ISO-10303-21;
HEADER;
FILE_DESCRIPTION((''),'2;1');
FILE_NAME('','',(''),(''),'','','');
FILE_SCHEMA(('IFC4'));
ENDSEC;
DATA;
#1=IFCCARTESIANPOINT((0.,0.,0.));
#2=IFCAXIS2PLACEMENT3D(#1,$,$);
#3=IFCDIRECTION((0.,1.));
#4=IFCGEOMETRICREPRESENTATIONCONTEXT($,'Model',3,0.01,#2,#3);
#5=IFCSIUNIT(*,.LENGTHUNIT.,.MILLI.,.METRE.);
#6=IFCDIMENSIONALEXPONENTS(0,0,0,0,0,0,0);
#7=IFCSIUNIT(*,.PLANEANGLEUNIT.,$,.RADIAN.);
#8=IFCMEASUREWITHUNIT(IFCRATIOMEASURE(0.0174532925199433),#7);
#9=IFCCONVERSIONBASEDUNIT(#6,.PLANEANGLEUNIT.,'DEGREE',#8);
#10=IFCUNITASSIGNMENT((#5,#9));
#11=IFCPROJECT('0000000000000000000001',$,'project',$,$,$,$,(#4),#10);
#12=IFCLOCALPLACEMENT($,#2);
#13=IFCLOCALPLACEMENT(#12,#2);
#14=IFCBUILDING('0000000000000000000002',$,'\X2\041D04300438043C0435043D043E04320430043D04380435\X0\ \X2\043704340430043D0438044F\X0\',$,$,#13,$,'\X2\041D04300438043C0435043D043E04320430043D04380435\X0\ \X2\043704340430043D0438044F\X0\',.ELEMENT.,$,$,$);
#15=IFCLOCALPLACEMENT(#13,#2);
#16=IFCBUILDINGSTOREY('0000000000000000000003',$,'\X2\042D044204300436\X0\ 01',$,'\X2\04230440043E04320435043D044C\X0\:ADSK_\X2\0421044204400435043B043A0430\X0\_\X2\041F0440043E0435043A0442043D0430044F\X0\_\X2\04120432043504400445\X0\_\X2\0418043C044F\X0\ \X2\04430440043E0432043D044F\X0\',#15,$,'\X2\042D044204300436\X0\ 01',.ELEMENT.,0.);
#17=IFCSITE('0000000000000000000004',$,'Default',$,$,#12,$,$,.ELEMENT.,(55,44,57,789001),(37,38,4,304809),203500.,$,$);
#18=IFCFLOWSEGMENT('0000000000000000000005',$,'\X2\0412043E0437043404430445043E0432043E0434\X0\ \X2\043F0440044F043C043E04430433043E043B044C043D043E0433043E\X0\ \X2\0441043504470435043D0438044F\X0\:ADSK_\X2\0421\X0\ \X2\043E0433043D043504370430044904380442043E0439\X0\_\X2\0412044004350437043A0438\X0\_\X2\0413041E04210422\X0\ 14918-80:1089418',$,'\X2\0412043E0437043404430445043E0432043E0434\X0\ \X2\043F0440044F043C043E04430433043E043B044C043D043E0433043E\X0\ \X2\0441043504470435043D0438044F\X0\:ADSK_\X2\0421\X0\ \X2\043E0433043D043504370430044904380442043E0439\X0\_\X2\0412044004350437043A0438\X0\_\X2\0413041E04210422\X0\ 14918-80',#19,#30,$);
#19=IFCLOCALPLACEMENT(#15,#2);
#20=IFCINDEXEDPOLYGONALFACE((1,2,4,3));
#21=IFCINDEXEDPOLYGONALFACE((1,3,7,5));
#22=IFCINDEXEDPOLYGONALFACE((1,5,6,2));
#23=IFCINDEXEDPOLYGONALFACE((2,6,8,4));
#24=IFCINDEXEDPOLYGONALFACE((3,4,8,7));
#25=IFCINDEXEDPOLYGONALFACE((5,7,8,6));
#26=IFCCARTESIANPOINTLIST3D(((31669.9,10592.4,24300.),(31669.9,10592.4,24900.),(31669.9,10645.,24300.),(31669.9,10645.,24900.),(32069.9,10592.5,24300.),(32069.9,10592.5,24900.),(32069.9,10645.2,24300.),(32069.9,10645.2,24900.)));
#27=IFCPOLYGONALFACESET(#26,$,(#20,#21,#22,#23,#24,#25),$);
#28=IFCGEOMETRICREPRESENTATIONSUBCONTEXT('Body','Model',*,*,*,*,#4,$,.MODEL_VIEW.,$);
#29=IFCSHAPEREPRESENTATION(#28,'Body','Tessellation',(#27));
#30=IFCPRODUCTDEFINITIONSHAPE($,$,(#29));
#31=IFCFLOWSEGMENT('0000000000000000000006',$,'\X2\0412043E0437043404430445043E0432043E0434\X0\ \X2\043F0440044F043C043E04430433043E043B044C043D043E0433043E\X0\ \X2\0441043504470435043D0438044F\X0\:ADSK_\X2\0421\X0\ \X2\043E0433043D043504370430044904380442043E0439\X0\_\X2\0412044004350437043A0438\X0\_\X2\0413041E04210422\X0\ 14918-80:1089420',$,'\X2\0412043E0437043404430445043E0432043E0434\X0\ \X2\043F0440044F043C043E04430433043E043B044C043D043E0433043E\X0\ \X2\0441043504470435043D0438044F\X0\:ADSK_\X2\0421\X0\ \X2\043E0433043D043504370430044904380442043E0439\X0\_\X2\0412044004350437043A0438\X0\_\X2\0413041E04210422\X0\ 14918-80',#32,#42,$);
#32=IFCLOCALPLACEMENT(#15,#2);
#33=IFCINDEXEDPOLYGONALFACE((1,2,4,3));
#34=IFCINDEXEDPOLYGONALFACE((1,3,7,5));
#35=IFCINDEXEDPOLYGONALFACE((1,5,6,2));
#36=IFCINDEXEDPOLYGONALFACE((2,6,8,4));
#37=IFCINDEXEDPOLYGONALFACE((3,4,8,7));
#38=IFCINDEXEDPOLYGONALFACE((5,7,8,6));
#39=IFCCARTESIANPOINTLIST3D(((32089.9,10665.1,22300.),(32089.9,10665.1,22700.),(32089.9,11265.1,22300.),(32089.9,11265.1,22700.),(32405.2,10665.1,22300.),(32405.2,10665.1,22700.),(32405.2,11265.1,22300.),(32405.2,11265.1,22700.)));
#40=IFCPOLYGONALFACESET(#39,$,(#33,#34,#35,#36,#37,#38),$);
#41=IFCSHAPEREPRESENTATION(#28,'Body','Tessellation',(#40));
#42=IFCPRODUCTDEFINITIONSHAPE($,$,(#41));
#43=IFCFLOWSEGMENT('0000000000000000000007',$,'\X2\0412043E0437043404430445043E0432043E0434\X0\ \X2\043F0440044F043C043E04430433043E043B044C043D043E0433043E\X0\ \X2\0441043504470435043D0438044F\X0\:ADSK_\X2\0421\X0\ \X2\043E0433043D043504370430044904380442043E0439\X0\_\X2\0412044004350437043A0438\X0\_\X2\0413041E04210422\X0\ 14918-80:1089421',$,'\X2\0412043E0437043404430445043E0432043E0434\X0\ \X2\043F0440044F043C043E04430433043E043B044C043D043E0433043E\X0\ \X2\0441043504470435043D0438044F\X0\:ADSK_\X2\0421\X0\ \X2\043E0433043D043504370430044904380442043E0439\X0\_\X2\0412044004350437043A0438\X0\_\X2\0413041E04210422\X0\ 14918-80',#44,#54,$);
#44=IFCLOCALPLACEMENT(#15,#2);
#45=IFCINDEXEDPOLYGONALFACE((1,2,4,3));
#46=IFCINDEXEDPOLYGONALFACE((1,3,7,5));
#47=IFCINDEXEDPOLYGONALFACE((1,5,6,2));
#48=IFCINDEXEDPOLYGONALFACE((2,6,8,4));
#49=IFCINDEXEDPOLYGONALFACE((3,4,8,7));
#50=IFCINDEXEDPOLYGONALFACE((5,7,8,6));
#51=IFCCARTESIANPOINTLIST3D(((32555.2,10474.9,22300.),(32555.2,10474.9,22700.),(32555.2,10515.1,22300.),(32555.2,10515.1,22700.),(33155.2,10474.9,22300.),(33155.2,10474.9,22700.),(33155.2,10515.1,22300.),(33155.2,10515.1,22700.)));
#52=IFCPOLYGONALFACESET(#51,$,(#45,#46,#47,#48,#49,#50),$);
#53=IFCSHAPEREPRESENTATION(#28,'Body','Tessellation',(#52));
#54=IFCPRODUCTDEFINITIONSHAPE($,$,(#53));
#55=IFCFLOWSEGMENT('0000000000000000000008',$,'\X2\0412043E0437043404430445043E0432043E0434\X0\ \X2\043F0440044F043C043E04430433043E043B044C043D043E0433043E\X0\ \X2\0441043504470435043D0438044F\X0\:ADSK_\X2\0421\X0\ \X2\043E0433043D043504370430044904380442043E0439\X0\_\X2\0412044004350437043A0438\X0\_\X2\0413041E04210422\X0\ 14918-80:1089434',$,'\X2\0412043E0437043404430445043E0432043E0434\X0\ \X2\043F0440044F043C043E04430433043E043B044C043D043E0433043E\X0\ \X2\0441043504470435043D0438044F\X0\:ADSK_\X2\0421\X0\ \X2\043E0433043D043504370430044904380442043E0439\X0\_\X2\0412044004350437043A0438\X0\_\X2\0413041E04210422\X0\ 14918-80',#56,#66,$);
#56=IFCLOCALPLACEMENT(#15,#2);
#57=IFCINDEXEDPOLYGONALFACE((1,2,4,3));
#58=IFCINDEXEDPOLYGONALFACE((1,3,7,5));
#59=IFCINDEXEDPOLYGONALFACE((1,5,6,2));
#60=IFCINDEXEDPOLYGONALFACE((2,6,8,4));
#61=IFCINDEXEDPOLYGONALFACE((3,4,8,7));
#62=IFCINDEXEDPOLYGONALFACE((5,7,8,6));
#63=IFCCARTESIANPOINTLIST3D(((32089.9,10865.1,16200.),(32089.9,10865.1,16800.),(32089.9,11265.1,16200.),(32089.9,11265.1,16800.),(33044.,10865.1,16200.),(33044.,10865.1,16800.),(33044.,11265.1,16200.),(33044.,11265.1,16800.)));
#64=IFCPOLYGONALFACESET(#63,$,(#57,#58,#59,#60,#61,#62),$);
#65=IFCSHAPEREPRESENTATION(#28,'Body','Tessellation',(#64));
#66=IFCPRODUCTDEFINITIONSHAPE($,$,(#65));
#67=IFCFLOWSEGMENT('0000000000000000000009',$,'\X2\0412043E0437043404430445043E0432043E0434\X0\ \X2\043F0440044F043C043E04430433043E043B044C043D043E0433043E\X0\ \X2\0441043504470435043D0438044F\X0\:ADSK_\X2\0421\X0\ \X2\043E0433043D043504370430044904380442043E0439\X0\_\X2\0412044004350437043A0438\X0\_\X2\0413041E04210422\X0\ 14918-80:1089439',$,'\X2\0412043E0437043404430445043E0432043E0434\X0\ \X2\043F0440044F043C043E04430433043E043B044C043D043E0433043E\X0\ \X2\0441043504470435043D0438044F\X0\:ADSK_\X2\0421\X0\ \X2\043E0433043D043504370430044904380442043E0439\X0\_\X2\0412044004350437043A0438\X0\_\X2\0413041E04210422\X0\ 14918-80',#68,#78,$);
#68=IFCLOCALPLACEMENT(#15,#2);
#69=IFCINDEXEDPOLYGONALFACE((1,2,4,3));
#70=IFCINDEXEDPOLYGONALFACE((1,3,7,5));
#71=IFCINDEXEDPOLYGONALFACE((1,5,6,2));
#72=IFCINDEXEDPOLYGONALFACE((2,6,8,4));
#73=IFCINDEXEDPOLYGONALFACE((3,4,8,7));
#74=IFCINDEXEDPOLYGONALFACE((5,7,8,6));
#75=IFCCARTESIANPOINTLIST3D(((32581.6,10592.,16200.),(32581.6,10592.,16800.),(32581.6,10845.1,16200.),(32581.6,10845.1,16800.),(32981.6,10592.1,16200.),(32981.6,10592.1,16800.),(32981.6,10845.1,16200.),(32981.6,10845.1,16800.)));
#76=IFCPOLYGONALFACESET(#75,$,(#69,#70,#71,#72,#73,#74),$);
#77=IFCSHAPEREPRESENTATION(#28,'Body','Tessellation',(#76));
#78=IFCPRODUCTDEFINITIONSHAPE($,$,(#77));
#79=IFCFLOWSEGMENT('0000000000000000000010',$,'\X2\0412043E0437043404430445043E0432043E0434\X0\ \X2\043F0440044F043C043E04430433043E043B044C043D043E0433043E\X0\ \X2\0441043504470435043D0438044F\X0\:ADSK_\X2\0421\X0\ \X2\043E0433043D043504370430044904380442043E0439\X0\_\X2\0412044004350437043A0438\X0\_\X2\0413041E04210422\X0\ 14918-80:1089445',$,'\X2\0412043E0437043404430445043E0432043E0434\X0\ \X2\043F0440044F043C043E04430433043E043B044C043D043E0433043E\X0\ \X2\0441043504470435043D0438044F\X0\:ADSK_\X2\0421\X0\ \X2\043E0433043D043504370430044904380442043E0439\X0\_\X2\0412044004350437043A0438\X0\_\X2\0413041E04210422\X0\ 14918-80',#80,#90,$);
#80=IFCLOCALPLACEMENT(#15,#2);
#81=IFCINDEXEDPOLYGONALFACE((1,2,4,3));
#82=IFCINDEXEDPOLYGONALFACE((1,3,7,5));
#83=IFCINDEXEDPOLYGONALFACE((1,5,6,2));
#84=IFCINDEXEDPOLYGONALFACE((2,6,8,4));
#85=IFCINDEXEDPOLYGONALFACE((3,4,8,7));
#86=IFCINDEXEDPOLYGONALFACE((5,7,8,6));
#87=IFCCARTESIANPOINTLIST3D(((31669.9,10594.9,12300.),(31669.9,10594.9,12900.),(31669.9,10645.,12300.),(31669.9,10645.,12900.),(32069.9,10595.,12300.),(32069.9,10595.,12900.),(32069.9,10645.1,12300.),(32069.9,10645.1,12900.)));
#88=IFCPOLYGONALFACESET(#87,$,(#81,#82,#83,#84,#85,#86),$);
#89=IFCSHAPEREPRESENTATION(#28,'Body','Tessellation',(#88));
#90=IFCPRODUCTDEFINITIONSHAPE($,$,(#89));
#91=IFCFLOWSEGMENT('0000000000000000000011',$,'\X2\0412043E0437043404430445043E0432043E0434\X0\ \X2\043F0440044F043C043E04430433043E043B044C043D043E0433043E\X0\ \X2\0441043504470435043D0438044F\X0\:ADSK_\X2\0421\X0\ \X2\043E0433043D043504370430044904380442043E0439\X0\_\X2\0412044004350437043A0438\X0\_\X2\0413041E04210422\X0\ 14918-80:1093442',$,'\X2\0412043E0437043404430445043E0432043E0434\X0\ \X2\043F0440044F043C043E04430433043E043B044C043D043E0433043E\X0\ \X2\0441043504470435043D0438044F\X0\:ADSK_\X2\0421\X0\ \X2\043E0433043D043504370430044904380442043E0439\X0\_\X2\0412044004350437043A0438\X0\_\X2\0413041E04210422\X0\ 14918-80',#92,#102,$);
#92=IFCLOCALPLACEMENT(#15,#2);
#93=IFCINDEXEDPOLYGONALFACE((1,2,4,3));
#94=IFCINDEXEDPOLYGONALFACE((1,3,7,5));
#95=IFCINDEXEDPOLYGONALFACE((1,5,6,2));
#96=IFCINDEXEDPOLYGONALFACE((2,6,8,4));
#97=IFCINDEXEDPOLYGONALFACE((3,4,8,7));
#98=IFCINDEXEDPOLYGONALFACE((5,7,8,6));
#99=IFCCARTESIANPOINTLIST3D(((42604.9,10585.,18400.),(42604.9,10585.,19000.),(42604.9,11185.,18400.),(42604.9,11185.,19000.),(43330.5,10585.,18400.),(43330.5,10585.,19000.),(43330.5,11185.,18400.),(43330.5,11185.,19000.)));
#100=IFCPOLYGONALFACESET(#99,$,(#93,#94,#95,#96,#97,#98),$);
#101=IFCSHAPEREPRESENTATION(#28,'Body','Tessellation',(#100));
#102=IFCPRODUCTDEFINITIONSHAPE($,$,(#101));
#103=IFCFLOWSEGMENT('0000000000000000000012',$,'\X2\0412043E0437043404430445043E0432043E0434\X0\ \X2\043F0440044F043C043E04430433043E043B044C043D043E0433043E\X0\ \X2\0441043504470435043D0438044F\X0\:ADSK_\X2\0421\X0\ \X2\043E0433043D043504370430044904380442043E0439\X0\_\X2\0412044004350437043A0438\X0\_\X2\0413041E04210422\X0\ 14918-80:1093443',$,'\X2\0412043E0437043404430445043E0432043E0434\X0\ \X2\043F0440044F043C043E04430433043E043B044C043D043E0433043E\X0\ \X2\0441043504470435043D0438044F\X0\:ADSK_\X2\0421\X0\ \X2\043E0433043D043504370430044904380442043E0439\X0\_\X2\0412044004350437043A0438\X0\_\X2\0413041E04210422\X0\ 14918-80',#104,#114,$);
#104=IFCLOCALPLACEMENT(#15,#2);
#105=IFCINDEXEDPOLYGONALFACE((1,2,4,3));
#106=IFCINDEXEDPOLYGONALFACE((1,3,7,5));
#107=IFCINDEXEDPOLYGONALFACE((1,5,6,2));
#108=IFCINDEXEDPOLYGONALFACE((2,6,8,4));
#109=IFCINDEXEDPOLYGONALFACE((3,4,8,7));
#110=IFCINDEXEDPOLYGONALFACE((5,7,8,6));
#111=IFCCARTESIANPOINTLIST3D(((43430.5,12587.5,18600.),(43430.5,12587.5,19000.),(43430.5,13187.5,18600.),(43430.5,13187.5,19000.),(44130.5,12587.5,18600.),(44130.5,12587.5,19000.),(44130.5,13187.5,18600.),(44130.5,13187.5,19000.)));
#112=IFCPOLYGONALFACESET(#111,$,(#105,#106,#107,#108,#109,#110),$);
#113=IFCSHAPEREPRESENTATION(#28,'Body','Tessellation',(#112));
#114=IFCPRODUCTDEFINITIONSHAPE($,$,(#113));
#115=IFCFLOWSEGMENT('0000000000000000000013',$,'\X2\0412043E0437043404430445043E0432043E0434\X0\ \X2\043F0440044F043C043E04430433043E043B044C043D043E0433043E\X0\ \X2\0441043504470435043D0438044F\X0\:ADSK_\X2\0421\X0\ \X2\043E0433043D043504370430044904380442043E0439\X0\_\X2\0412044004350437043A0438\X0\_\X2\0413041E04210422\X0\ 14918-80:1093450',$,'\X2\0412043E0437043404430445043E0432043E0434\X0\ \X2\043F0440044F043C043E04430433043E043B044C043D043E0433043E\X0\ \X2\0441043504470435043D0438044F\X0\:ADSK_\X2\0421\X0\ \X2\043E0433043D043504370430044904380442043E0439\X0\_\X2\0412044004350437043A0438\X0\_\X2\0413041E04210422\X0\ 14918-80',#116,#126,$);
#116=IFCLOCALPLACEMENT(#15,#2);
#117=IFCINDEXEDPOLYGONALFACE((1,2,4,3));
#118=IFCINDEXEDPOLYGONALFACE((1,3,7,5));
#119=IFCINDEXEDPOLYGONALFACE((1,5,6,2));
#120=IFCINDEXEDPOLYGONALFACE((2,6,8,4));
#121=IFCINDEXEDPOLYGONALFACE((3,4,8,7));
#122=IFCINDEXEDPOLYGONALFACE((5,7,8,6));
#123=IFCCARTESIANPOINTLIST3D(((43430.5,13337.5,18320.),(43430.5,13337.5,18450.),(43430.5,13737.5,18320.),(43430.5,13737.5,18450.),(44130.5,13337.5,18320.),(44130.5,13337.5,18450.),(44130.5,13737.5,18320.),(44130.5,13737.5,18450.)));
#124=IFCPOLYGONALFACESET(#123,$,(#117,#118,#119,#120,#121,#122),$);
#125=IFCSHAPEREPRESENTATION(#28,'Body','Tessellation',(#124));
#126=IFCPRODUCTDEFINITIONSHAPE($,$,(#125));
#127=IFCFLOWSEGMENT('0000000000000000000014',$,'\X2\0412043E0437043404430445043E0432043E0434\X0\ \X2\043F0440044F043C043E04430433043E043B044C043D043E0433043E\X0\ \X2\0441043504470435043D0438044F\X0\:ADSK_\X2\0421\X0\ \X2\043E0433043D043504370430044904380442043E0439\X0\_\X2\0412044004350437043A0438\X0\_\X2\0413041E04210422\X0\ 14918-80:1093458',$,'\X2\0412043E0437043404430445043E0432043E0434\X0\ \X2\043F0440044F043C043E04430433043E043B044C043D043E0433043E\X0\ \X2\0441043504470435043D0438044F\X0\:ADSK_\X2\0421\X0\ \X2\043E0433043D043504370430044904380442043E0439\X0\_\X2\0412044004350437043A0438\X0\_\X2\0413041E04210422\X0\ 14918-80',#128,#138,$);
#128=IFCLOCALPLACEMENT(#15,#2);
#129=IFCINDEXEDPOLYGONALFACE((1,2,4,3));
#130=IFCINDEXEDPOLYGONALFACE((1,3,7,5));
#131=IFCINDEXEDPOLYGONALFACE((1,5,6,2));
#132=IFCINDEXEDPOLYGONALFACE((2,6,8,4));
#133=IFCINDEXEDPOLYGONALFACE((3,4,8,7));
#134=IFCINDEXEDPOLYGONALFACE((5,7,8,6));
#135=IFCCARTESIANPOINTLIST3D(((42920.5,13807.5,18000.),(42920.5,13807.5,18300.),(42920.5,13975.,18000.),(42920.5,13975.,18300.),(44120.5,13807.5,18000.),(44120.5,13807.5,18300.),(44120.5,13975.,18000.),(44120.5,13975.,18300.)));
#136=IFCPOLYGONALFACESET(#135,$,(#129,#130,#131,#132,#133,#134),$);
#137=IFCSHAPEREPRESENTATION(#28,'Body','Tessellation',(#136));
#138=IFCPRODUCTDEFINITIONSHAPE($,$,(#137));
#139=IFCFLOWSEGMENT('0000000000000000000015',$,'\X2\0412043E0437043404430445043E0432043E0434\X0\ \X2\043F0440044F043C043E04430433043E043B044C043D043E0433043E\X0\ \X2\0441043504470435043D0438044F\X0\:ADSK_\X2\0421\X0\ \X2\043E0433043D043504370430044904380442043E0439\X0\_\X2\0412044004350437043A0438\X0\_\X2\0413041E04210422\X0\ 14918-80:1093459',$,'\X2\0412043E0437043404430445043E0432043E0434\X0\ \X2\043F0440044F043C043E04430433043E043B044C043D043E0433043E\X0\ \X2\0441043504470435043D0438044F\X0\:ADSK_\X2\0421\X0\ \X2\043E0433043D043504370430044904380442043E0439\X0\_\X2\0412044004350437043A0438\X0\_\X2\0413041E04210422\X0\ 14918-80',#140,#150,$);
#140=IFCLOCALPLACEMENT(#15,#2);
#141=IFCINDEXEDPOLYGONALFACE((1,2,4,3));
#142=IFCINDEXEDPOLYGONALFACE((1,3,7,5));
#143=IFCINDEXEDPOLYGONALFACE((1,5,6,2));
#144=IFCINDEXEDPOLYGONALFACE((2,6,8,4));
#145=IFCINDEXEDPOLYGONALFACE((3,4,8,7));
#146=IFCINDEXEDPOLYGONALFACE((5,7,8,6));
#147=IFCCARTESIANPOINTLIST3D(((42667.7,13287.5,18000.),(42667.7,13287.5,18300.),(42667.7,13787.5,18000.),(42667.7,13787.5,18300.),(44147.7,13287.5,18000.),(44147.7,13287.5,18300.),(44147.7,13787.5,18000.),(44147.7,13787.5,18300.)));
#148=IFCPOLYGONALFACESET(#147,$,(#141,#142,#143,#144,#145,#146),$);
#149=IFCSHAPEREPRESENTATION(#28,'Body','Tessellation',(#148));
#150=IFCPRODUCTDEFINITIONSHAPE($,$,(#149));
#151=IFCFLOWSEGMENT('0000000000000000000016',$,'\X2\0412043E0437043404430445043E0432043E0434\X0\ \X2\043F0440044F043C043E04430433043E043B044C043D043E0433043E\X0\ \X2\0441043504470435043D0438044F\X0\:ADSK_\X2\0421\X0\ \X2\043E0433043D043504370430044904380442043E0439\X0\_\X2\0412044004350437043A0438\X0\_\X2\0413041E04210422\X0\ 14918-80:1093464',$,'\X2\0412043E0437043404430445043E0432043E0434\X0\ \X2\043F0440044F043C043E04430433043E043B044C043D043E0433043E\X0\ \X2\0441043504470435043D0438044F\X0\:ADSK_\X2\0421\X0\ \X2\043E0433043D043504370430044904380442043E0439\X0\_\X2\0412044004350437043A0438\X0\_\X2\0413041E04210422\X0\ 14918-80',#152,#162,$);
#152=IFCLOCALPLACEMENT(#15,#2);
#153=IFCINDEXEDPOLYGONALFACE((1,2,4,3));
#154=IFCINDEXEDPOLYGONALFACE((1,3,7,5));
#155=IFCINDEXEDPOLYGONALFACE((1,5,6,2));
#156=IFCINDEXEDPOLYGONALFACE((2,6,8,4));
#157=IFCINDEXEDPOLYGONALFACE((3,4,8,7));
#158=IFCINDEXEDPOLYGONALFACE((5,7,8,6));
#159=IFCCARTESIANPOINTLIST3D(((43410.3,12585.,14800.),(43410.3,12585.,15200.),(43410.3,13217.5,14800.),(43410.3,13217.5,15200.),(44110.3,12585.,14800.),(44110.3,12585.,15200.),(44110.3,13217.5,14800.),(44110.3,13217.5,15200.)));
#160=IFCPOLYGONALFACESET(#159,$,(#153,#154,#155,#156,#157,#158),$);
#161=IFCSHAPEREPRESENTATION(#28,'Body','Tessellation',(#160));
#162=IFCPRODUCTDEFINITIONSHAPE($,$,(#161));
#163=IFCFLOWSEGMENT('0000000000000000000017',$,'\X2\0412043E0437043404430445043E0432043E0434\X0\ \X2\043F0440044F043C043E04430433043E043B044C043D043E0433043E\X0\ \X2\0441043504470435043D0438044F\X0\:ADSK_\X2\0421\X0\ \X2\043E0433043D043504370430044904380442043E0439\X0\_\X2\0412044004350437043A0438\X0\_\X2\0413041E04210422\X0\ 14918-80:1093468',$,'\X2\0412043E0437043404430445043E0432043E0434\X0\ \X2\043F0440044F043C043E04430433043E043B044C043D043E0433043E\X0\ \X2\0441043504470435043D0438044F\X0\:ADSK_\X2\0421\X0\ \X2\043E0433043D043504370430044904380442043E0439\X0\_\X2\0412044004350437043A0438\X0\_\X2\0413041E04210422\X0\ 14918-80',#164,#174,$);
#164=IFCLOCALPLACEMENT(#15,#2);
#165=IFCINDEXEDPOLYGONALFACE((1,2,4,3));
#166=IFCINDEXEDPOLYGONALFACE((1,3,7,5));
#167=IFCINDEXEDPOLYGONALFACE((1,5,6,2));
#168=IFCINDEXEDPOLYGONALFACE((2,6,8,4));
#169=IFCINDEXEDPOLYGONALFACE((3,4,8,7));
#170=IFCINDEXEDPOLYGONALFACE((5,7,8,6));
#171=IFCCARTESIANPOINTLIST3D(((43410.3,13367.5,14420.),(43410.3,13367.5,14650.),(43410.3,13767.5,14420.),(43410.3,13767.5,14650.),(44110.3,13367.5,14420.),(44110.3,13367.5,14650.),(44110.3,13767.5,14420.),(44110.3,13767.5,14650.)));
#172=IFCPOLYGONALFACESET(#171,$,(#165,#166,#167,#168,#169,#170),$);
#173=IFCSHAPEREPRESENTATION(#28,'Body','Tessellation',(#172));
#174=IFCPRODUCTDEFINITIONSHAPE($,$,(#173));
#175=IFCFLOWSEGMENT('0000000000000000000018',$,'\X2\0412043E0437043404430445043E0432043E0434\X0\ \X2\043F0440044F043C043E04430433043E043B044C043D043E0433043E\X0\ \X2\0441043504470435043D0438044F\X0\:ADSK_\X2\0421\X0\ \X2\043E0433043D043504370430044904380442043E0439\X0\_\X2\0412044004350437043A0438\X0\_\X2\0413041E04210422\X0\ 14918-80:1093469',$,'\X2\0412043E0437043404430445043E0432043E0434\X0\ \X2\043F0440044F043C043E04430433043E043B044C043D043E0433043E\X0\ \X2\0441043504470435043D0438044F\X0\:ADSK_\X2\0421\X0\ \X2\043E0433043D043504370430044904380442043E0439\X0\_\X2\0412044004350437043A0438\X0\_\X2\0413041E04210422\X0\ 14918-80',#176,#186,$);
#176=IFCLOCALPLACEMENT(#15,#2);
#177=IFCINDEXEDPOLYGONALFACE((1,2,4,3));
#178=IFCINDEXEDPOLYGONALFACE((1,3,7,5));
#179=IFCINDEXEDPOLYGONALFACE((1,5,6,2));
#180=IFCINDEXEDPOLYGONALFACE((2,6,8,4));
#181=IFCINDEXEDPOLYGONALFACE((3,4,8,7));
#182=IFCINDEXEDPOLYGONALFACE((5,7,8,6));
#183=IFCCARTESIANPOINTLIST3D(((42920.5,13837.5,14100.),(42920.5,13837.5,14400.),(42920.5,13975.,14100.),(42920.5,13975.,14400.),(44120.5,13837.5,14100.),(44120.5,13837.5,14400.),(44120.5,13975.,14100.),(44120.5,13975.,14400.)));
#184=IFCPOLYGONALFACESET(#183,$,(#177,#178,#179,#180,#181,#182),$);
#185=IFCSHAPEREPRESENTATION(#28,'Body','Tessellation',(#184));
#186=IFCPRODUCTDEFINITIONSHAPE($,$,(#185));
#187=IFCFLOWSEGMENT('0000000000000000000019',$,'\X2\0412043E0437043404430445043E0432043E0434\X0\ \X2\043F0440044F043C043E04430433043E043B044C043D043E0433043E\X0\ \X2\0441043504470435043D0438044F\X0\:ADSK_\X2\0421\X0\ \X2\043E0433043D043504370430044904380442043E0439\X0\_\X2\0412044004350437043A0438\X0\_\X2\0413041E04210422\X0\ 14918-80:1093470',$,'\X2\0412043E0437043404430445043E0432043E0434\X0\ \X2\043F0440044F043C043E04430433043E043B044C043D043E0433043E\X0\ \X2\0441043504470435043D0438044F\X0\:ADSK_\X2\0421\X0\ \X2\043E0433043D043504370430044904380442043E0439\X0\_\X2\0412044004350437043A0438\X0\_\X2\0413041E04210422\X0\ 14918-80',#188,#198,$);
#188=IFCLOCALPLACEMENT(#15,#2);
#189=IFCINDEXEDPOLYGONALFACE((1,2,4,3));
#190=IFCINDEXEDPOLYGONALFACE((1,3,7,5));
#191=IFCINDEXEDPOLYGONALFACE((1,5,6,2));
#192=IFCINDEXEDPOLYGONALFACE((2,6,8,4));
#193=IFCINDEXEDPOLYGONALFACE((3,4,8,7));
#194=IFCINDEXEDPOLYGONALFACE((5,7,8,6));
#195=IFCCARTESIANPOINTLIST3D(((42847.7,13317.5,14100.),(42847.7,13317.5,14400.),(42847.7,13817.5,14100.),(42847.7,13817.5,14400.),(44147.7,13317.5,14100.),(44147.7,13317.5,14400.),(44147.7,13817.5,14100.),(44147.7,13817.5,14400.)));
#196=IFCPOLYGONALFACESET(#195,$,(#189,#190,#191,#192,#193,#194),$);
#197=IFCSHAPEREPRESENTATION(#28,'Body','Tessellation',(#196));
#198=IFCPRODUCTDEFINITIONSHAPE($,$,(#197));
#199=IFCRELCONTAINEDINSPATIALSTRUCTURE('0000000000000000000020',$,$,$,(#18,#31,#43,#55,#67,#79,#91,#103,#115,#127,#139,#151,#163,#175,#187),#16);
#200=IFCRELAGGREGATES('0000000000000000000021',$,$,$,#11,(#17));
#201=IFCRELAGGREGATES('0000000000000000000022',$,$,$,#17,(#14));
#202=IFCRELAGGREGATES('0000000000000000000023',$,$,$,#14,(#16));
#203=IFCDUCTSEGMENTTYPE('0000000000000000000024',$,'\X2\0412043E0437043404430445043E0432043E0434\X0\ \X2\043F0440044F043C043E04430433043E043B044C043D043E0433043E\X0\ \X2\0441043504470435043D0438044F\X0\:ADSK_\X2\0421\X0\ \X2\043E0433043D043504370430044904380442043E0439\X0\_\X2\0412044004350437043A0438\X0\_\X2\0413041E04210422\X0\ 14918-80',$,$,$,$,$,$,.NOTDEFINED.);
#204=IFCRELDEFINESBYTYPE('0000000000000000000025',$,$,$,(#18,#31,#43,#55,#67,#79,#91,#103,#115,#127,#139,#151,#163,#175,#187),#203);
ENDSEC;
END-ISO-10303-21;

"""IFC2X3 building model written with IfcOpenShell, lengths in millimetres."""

from ifc_helpers import new_model, entity, si_unit, converted_unit, direction, frame, origin, origin_2d_with_axis, place, context, subcontext, project, spatial, rectangle, extrude, type_object, element, save


model = new_model("IFC2X3")

# Units and contexts
model_context = context("Model", 3, precision=0.01, world=origin(), true_north=direction((0.0, 1.0)))
body_context = subcontext(model_context, "Body", "Model", "MODEL_VIEW")
ifc_project = project(units=[si_unit("LENGTHUNIT", "METRE", prefix="MILLI"), converted_unit("PLANEANGLEUNIT", "DEGREE", entity("IfcRatioMeasure", 0.0174532925199433), si_unit("PLANEANGLEUNIT", "RADIAN"), dimensions=[0, 0, 0, 0, 0, 0, 0])], contexts=[model_context])

# Site, building, storey
site_placement = place(None, origin())
site = spatial("IfcSite", under=ifc_project, at=site_placement, Name="Default", CompositionType="ELEMENT", RefLatitude=(55, 44, 57, 789001), RefLongitude=(37, 38, 4, 304809), RefElevation=203500.0)
building_placement = place(site_placement, origin())
building = spatial("IfcBuilding", under=site, at=building_placement, Name="Наименование здания", LongName="Наименование здания", CompositionType="ELEMENT")
storey_placement = place(building_placement, origin())
storey = spatial("IfcBuildingStorey", under=building, at=storey_placement, Name="Этаж 01", ObjectType="Уровень:ADSK_Стрелка_Проектная_Вверх_Имя уровня", LongName="Этаж 01", CompositionType="ELEMENT", Elevation=0.0)

# Flow segments
duct_segment_type = type_object("IfcDuctSegmentType", Name="Воздуховод прямоугольного сечения:ADSK_С огнезащитой_Врезки_ГОСТ 14918-80", PredefinedType="NOTDEFINED")
flow_segment_1_placement = place(storey_placement, frame((31669.9, 10592.4, 24300.0)))
element("IfcFlowSegment", 1, at=flow_segment_1_placement, inside=storey, type_object=duct_segment_type, Name="Воздуховод прямоугольного сечения:ADSK_С огнезащитой_Врезки_ГОСТ 14918-80:1089418", ObjectType="Воздуховод прямоугольного сечения:ADSK_С огнезащитой_Врезки_ГОСТ 14918-80", context=body_context, shape_type="SweptSolid", body=[
    extrude(rectangle(XDim=52.7, YDim=400.0, at=origin_2d_with_axis()), frame((200.0, 26.4, 0.0), z_axis=(0.0, 0.0, 1.0), x_axis=(0.000312, -1.0, 0.0)), (0.0, 0.0, 1.0), 600.0),
])
flow_segment_2_placement = place(storey_placement, frame((32089.9, 10665.1, 22300.0)))
element("IfcFlowSegment", 2, at=flow_segment_2_placement, inside=storey, type_object=duct_segment_type, Name="Воздуховод прямоугольного сечения:ADSK_С огнезащитой_Врезки_ГОСТ 14918-80:1089420", ObjectType="Воздуховод прямоугольного сечения:ADSK_С огнезащитой_Врезки_ГОСТ 14918-80", context=body_context, shape_type="SweptSolid", body=[
    extrude(rectangle(XDim=315.3, YDim=600.0, at=origin_2d_with_axis()), frame((157.7, 300.0, 0.0), z_axis=(0.0, 0.0, 1.0), x_axis=(-1.0, 0.0, 0.0)), (0.0, 0.0, 1.0), 400.0),
])
flow_segment_3_placement = place(storey_placement, frame((32555.2, 10474.9, 22300.0)))
element("IfcFlowSegment", 3, at=flow_segment_3_placement, inside=storey, type_object=duct_segment_type, Name="Воздуховод прямоугольного сечения:ADSK_С огнезащитой_Врезки_ГОСТ 14918-80:1089421", ObjectType="Воздуховод прямоугольного сечения:ADSK_С огнезащитой_Врезки_ГОСТ 14918-80", context=body_context, shape_type="SweptSolid", body=[
    extrude(rectangle(XDim=40.2, YDim=600.0, at=origin_2d_with_axis()), frame((300.0, 20.1, 0.0), z_axis=(0.0, 0.0, 1.0), x_axis=(0.0, 1.0, 0.0)), (0.0, 0.0, 1.0), 400.0),
])
flow_segment_4_placement = place(storey_placement, frame((32089.9, 10865.1, 16200.0)))
element("IfcFlowSegment", 4, at=flow_segment_4_placement, inside=storey, type_object=duct_segment_type, Name="Воздуховод прямоугольного сечения:ADSK_С огнезащитой_Врезки_ГОСТ 14918-80:1089434", ObjectType="Воздуховод прямоугольного сечения:ADSK_С огнезащитой_Врезки_ГОСТ 14918-80", context=body_context, shape_type="SweptSolid", body=[
    extrude(rectangle(XDim=954.2, YDim=400.0, at=origin_2d_with_axis()), frame((477.1, 200.0, 0.0)), (0.0, 0.0, 1.0), 600.0),
])
flow_segment_5_placement = place(storey_placement, frame((32581.6, 10592.0, 16200.0)))
element("IfcFlowSegment", 5, at=flow_segment_5_placement, inside=storey, type_object=duct_segment_type, Name="Воздуховод прямоугольного сечения:ADSK_С огнезащитой_Врезки_ГОСТ 14918-80:1089439", ObjectType="Воздуховод прямоугольного сечения:ADSK_С огнезащитой_Врезки_ГОСТ 14918-80", context=body_context, shape_type="SweptSolid", body=[
    extrude(rectangle(XDim=253.0, YDim=400.0, at=origin_2d_with_axis()), frame((200.0, 126.5, 0.0), z_axis=(0.0, 0.0, 1.0), x_axis=(0.000065, -1.0, 0.0)), (0.0, 0.0, 1.0), 600.0),
])
flow_segment_6_placement = place(storey_placement, frame((31669.9, 10595.0, 12300.0)))
element("IfcFlowSegment", 6, at=flow_segment_6_placement, inside=storey, type_object=duct_segment_type, Name="Воздуховод прямоугольного сечения:ADSK_С огнезащитой_Врезки_ГОСТ 14918-80:1089445", ObjectType="Воздуховод прямоугольного сечения:ADSK_С огнезащитой_Врезки_ГОСТ 14918-80", context=body_context, shape_type="SweptSolid", body=[
    extrude(rectangle(XDim=50.1, YDim=400.0, at=origin_2d_with_axis()), frame((200.0, 25.1, 0.0), z_axis=(0.0, 0.0, 1.0), x_axis=(0.000234, -1.0, 0.0)), (0.0, 0.0, 1.0), 600.0),
])
flow_segment_7_placement = place(storey_placement, frame((42604.9, 10585.0, 18400.0)))
element("IfcFlowSegment", 7, at=flow_segment_7_placement, inside=storey, type_object=duct_segment_type, Name="Воздуховод прямоугольного сечения:ADSK_С огнезащитой_Врезки_ГОСТ 14918-80:1093442", ObjectType="Воздуховод прямоугольного сечения:ADSK_С огнезащитой_Врезки_ГОСТ 14918-80", context=body_context, shape_type="SweptSolid", body=[
    extrude(rectangle(XDim=725.7, YDim=600.0, at=origin_2d_with_axis()), frame((362.8, 300.0, 0.0)), (0.0, 0.0, 1.0), 600.0),
])
flow_segment_8_placement = place(storey_placement, frame((43430.5, 12587.5, 18600.0)))
element("IfcFlowSegment", 8, at=flow_segment_8_placement, inside=storey, type_object=duct_segment_type, Name="Воздуховод прямоугольного сечения:ADSK_С огнезащитой_Врезки_ГОСТ 14918-80:1093443", ObjectType="Воздуховод прямоугольного сечения:ADSK_С огнезащитой_Врезки_ГОСТ 14918-80", context=body_context, shape_type="SweptSolid", body=[
    extrude(rectangle(XDim=600.0, YDim=700.0, at=origin_2d_with_axis()), frame((350.0, 300.0, 0.0), z_axis=(0.0, 0.0, 1.0), x_axis=(0.0, -1.0, 0.0)), (0.0, 0.0, 1.0), 400.0),
])
flow_segment_9_placement = place(storey_placement, frame((43430.5, 13337.5, 18320.0)))
element("IfcFlowSegment", 9, at=flow_segment_9_placement, inside=storey, type_object=duct_segment_type, Name="Воздуховод прямоугольного сечения:ADSK_С огнезащитой_Врезки_ГОСТ 14918-80:1093450", ObjectType="Воздуховод прямоугольного сечения:ADSK_С огнезащитой_Врезки_ГОСТ 14918-80", context=body_context, shape_type="SweptSolid", body=[
    extrude(rectangle(XDim=700.0, YDim=400.0, at=origin_2d_with_axis()), frame((350.0, 200.0, 0.0)), (0.0, 0.0, 1.0), 130.0),
])
flow_segment_10_placement = place(storey_placement, frame((42920.5, 13807.5, 18000.0)))
element("IfcFlowSegment", 10, at=flow_segment_10_placement, inside=storey, type_object=duct_segment_type, Name="Воздуховод прямоугольного сечения:ADSK_С огнезащитой_Врезки_ГОСТ 14918-80:1093458", ObjectType="Воздуховод прямоугольного сечения:ADSK_С огнезащитой_Врезки_ГОСТ 14918-80", context=body_context, shape_type="SweptSolid", body=[
    extrude(rectangle(XDim=167.5, YDim=1200.0, at=origin_2d_with_axis()), frame((600.0, 83.8, 0.0), z_axis=(0.0, 0.0, 1.0), x_axis=(0.0, -1.0, 0.0)), (0.0, 0.0, 1.0), 300.0),
])
flow_segment_11_placement = place(storey_placement, frame((42667.7, 13287.5, 18000.0)))
element("IfcFlowSegment", 11, at=flow_segment_11_placement, inside=storey, type_object=duct_segment_type, Name="Воздуховод прямоугольного сечения:ADSK_С огнезащитой_Врезки_ГОСТ 14918-80:1093459", ObjectType="Воздуховод прямоугольного сечения:ADSK_С огнезащитой_Врезки_ГОСТ 14918-80", context=body_context, shape_type="SweptSolid", body=[
    extrude(rectangle(XDim=1480.0, YDim=500.0, at=origin_2d_with_axis()), frame((740.0, 250.0, 0.0)), (0.0, 0.0, 1.0), 300.0),
])
flow_segment_12_placement = place(storey_placement, frame((43410.3, 12585.0, 14800.0)))
element("IfcFlowSegment", 12, at=flow_segment_12_placement, inside=storey, type_object=duct_segment_type, Name="Воздуховод прямоугольного сечения:ADSK_С огнезащитой_Врезки_ГОСТ 14918-80:1093464", ObjectType="Воздуховод прямоугольного сечения:ADSK_С огнезащитой_Врезки_ГОСТ 14918-80", context=body_context, shape_type="SweptSolid", body=[
    extrude(rectangle(XDim=632.5, YDim=700.0, at=origin_2d_with_axis()), frame((350.0, 316.2, 0.0), z_axis=(0.0, 0.0, 1.0), x_axis=(0.0, -1.0, 0.0)), (0.0, 0.0, 1.0), 400.0),
])
flow_segment_13_placement = place(storey_placement, frame((43410.3, 13367.5, 14420.0)))
element("IfcFlowSegment", 13, at=flow_segment_13_placement, inside=storey, type_object=duct_segment_type, Name="Воздуховод прямоугольного сечения:ADSK_С огнезащитой_Врезки_ГОСТ 14918-80:1093468", ObjectType="Воздуховод прямоугольного сечения:ADSK_С огнезащитой_Врезки_ГОСТ 14918-80", context=body_context, shape_type="SweptSolid", body=[
    extrude(rectangle(XDim=700.0, YDim=400.0, at=origin_2d_with_axis()), frame((350.0, 200.0, 0.0)), (0.0, 0.0, 1.0), 230.0),
])
flow_segment_14_placement = place(storey_placement, frame((42920.5, 13837.5, 14100.0)))
element("IfcFlowSegment", 14, at=flow_segment_14_placement, inside=storey, type_object=duct_segment_type, Name="Воздуховод прямоугольного сечения:ADSK_С огнезащитой_Врезки_ГОСТ 14918-80:1093469", ObjectType="Воздуховод прямоугольного сечения:ADSK_С огнезащитой_Врезки_ГОСТ 14918-80", context=body_context, shape_type="SweptSolid", body=[
    extrude(rectangle(XDim=137.5, YDim=1200.0, at=origin_2d_with_axis()), frame((600.0, 68.8, 0.0), z_axis=(0.0, 0.0, 1.0), x_axis=(0.0, -1.0, 0.0)), (0.0, 0.0, 1.0), 300.0),
])
flow_segment_15_placement = place(storey_placement, frame((42847.7, 13317.5, 14100.0)))
element("IfcFlowSegment", 15, at=flow_segment_15_placement, inside=storey, type_object=duct_segment_type, Name="Воздуховод прямоугольного сечения:ADSK_С огнезащитой_Врезки_ГОСТ 14918-80:1093470", ObjectType="Воздуховод прямоугольного сечения:ADSK_С огнезащитой_Врезки_ГОСТ 14918-80", context=body_context, shape_type="SweptSolid", body=[
    extrude(rectangle(XDim=1300.0, YDim=500.0, at=origin_2d_with_axis()), frame((650.0, 250.0, 0.0), z_axis=(0.0, 0.0, 1.0), x_axis=(-1.0, 0.0, 0.0)), (0.0, 0.0, 1.0), 300.0),
])

save(model, "model.ifc")
